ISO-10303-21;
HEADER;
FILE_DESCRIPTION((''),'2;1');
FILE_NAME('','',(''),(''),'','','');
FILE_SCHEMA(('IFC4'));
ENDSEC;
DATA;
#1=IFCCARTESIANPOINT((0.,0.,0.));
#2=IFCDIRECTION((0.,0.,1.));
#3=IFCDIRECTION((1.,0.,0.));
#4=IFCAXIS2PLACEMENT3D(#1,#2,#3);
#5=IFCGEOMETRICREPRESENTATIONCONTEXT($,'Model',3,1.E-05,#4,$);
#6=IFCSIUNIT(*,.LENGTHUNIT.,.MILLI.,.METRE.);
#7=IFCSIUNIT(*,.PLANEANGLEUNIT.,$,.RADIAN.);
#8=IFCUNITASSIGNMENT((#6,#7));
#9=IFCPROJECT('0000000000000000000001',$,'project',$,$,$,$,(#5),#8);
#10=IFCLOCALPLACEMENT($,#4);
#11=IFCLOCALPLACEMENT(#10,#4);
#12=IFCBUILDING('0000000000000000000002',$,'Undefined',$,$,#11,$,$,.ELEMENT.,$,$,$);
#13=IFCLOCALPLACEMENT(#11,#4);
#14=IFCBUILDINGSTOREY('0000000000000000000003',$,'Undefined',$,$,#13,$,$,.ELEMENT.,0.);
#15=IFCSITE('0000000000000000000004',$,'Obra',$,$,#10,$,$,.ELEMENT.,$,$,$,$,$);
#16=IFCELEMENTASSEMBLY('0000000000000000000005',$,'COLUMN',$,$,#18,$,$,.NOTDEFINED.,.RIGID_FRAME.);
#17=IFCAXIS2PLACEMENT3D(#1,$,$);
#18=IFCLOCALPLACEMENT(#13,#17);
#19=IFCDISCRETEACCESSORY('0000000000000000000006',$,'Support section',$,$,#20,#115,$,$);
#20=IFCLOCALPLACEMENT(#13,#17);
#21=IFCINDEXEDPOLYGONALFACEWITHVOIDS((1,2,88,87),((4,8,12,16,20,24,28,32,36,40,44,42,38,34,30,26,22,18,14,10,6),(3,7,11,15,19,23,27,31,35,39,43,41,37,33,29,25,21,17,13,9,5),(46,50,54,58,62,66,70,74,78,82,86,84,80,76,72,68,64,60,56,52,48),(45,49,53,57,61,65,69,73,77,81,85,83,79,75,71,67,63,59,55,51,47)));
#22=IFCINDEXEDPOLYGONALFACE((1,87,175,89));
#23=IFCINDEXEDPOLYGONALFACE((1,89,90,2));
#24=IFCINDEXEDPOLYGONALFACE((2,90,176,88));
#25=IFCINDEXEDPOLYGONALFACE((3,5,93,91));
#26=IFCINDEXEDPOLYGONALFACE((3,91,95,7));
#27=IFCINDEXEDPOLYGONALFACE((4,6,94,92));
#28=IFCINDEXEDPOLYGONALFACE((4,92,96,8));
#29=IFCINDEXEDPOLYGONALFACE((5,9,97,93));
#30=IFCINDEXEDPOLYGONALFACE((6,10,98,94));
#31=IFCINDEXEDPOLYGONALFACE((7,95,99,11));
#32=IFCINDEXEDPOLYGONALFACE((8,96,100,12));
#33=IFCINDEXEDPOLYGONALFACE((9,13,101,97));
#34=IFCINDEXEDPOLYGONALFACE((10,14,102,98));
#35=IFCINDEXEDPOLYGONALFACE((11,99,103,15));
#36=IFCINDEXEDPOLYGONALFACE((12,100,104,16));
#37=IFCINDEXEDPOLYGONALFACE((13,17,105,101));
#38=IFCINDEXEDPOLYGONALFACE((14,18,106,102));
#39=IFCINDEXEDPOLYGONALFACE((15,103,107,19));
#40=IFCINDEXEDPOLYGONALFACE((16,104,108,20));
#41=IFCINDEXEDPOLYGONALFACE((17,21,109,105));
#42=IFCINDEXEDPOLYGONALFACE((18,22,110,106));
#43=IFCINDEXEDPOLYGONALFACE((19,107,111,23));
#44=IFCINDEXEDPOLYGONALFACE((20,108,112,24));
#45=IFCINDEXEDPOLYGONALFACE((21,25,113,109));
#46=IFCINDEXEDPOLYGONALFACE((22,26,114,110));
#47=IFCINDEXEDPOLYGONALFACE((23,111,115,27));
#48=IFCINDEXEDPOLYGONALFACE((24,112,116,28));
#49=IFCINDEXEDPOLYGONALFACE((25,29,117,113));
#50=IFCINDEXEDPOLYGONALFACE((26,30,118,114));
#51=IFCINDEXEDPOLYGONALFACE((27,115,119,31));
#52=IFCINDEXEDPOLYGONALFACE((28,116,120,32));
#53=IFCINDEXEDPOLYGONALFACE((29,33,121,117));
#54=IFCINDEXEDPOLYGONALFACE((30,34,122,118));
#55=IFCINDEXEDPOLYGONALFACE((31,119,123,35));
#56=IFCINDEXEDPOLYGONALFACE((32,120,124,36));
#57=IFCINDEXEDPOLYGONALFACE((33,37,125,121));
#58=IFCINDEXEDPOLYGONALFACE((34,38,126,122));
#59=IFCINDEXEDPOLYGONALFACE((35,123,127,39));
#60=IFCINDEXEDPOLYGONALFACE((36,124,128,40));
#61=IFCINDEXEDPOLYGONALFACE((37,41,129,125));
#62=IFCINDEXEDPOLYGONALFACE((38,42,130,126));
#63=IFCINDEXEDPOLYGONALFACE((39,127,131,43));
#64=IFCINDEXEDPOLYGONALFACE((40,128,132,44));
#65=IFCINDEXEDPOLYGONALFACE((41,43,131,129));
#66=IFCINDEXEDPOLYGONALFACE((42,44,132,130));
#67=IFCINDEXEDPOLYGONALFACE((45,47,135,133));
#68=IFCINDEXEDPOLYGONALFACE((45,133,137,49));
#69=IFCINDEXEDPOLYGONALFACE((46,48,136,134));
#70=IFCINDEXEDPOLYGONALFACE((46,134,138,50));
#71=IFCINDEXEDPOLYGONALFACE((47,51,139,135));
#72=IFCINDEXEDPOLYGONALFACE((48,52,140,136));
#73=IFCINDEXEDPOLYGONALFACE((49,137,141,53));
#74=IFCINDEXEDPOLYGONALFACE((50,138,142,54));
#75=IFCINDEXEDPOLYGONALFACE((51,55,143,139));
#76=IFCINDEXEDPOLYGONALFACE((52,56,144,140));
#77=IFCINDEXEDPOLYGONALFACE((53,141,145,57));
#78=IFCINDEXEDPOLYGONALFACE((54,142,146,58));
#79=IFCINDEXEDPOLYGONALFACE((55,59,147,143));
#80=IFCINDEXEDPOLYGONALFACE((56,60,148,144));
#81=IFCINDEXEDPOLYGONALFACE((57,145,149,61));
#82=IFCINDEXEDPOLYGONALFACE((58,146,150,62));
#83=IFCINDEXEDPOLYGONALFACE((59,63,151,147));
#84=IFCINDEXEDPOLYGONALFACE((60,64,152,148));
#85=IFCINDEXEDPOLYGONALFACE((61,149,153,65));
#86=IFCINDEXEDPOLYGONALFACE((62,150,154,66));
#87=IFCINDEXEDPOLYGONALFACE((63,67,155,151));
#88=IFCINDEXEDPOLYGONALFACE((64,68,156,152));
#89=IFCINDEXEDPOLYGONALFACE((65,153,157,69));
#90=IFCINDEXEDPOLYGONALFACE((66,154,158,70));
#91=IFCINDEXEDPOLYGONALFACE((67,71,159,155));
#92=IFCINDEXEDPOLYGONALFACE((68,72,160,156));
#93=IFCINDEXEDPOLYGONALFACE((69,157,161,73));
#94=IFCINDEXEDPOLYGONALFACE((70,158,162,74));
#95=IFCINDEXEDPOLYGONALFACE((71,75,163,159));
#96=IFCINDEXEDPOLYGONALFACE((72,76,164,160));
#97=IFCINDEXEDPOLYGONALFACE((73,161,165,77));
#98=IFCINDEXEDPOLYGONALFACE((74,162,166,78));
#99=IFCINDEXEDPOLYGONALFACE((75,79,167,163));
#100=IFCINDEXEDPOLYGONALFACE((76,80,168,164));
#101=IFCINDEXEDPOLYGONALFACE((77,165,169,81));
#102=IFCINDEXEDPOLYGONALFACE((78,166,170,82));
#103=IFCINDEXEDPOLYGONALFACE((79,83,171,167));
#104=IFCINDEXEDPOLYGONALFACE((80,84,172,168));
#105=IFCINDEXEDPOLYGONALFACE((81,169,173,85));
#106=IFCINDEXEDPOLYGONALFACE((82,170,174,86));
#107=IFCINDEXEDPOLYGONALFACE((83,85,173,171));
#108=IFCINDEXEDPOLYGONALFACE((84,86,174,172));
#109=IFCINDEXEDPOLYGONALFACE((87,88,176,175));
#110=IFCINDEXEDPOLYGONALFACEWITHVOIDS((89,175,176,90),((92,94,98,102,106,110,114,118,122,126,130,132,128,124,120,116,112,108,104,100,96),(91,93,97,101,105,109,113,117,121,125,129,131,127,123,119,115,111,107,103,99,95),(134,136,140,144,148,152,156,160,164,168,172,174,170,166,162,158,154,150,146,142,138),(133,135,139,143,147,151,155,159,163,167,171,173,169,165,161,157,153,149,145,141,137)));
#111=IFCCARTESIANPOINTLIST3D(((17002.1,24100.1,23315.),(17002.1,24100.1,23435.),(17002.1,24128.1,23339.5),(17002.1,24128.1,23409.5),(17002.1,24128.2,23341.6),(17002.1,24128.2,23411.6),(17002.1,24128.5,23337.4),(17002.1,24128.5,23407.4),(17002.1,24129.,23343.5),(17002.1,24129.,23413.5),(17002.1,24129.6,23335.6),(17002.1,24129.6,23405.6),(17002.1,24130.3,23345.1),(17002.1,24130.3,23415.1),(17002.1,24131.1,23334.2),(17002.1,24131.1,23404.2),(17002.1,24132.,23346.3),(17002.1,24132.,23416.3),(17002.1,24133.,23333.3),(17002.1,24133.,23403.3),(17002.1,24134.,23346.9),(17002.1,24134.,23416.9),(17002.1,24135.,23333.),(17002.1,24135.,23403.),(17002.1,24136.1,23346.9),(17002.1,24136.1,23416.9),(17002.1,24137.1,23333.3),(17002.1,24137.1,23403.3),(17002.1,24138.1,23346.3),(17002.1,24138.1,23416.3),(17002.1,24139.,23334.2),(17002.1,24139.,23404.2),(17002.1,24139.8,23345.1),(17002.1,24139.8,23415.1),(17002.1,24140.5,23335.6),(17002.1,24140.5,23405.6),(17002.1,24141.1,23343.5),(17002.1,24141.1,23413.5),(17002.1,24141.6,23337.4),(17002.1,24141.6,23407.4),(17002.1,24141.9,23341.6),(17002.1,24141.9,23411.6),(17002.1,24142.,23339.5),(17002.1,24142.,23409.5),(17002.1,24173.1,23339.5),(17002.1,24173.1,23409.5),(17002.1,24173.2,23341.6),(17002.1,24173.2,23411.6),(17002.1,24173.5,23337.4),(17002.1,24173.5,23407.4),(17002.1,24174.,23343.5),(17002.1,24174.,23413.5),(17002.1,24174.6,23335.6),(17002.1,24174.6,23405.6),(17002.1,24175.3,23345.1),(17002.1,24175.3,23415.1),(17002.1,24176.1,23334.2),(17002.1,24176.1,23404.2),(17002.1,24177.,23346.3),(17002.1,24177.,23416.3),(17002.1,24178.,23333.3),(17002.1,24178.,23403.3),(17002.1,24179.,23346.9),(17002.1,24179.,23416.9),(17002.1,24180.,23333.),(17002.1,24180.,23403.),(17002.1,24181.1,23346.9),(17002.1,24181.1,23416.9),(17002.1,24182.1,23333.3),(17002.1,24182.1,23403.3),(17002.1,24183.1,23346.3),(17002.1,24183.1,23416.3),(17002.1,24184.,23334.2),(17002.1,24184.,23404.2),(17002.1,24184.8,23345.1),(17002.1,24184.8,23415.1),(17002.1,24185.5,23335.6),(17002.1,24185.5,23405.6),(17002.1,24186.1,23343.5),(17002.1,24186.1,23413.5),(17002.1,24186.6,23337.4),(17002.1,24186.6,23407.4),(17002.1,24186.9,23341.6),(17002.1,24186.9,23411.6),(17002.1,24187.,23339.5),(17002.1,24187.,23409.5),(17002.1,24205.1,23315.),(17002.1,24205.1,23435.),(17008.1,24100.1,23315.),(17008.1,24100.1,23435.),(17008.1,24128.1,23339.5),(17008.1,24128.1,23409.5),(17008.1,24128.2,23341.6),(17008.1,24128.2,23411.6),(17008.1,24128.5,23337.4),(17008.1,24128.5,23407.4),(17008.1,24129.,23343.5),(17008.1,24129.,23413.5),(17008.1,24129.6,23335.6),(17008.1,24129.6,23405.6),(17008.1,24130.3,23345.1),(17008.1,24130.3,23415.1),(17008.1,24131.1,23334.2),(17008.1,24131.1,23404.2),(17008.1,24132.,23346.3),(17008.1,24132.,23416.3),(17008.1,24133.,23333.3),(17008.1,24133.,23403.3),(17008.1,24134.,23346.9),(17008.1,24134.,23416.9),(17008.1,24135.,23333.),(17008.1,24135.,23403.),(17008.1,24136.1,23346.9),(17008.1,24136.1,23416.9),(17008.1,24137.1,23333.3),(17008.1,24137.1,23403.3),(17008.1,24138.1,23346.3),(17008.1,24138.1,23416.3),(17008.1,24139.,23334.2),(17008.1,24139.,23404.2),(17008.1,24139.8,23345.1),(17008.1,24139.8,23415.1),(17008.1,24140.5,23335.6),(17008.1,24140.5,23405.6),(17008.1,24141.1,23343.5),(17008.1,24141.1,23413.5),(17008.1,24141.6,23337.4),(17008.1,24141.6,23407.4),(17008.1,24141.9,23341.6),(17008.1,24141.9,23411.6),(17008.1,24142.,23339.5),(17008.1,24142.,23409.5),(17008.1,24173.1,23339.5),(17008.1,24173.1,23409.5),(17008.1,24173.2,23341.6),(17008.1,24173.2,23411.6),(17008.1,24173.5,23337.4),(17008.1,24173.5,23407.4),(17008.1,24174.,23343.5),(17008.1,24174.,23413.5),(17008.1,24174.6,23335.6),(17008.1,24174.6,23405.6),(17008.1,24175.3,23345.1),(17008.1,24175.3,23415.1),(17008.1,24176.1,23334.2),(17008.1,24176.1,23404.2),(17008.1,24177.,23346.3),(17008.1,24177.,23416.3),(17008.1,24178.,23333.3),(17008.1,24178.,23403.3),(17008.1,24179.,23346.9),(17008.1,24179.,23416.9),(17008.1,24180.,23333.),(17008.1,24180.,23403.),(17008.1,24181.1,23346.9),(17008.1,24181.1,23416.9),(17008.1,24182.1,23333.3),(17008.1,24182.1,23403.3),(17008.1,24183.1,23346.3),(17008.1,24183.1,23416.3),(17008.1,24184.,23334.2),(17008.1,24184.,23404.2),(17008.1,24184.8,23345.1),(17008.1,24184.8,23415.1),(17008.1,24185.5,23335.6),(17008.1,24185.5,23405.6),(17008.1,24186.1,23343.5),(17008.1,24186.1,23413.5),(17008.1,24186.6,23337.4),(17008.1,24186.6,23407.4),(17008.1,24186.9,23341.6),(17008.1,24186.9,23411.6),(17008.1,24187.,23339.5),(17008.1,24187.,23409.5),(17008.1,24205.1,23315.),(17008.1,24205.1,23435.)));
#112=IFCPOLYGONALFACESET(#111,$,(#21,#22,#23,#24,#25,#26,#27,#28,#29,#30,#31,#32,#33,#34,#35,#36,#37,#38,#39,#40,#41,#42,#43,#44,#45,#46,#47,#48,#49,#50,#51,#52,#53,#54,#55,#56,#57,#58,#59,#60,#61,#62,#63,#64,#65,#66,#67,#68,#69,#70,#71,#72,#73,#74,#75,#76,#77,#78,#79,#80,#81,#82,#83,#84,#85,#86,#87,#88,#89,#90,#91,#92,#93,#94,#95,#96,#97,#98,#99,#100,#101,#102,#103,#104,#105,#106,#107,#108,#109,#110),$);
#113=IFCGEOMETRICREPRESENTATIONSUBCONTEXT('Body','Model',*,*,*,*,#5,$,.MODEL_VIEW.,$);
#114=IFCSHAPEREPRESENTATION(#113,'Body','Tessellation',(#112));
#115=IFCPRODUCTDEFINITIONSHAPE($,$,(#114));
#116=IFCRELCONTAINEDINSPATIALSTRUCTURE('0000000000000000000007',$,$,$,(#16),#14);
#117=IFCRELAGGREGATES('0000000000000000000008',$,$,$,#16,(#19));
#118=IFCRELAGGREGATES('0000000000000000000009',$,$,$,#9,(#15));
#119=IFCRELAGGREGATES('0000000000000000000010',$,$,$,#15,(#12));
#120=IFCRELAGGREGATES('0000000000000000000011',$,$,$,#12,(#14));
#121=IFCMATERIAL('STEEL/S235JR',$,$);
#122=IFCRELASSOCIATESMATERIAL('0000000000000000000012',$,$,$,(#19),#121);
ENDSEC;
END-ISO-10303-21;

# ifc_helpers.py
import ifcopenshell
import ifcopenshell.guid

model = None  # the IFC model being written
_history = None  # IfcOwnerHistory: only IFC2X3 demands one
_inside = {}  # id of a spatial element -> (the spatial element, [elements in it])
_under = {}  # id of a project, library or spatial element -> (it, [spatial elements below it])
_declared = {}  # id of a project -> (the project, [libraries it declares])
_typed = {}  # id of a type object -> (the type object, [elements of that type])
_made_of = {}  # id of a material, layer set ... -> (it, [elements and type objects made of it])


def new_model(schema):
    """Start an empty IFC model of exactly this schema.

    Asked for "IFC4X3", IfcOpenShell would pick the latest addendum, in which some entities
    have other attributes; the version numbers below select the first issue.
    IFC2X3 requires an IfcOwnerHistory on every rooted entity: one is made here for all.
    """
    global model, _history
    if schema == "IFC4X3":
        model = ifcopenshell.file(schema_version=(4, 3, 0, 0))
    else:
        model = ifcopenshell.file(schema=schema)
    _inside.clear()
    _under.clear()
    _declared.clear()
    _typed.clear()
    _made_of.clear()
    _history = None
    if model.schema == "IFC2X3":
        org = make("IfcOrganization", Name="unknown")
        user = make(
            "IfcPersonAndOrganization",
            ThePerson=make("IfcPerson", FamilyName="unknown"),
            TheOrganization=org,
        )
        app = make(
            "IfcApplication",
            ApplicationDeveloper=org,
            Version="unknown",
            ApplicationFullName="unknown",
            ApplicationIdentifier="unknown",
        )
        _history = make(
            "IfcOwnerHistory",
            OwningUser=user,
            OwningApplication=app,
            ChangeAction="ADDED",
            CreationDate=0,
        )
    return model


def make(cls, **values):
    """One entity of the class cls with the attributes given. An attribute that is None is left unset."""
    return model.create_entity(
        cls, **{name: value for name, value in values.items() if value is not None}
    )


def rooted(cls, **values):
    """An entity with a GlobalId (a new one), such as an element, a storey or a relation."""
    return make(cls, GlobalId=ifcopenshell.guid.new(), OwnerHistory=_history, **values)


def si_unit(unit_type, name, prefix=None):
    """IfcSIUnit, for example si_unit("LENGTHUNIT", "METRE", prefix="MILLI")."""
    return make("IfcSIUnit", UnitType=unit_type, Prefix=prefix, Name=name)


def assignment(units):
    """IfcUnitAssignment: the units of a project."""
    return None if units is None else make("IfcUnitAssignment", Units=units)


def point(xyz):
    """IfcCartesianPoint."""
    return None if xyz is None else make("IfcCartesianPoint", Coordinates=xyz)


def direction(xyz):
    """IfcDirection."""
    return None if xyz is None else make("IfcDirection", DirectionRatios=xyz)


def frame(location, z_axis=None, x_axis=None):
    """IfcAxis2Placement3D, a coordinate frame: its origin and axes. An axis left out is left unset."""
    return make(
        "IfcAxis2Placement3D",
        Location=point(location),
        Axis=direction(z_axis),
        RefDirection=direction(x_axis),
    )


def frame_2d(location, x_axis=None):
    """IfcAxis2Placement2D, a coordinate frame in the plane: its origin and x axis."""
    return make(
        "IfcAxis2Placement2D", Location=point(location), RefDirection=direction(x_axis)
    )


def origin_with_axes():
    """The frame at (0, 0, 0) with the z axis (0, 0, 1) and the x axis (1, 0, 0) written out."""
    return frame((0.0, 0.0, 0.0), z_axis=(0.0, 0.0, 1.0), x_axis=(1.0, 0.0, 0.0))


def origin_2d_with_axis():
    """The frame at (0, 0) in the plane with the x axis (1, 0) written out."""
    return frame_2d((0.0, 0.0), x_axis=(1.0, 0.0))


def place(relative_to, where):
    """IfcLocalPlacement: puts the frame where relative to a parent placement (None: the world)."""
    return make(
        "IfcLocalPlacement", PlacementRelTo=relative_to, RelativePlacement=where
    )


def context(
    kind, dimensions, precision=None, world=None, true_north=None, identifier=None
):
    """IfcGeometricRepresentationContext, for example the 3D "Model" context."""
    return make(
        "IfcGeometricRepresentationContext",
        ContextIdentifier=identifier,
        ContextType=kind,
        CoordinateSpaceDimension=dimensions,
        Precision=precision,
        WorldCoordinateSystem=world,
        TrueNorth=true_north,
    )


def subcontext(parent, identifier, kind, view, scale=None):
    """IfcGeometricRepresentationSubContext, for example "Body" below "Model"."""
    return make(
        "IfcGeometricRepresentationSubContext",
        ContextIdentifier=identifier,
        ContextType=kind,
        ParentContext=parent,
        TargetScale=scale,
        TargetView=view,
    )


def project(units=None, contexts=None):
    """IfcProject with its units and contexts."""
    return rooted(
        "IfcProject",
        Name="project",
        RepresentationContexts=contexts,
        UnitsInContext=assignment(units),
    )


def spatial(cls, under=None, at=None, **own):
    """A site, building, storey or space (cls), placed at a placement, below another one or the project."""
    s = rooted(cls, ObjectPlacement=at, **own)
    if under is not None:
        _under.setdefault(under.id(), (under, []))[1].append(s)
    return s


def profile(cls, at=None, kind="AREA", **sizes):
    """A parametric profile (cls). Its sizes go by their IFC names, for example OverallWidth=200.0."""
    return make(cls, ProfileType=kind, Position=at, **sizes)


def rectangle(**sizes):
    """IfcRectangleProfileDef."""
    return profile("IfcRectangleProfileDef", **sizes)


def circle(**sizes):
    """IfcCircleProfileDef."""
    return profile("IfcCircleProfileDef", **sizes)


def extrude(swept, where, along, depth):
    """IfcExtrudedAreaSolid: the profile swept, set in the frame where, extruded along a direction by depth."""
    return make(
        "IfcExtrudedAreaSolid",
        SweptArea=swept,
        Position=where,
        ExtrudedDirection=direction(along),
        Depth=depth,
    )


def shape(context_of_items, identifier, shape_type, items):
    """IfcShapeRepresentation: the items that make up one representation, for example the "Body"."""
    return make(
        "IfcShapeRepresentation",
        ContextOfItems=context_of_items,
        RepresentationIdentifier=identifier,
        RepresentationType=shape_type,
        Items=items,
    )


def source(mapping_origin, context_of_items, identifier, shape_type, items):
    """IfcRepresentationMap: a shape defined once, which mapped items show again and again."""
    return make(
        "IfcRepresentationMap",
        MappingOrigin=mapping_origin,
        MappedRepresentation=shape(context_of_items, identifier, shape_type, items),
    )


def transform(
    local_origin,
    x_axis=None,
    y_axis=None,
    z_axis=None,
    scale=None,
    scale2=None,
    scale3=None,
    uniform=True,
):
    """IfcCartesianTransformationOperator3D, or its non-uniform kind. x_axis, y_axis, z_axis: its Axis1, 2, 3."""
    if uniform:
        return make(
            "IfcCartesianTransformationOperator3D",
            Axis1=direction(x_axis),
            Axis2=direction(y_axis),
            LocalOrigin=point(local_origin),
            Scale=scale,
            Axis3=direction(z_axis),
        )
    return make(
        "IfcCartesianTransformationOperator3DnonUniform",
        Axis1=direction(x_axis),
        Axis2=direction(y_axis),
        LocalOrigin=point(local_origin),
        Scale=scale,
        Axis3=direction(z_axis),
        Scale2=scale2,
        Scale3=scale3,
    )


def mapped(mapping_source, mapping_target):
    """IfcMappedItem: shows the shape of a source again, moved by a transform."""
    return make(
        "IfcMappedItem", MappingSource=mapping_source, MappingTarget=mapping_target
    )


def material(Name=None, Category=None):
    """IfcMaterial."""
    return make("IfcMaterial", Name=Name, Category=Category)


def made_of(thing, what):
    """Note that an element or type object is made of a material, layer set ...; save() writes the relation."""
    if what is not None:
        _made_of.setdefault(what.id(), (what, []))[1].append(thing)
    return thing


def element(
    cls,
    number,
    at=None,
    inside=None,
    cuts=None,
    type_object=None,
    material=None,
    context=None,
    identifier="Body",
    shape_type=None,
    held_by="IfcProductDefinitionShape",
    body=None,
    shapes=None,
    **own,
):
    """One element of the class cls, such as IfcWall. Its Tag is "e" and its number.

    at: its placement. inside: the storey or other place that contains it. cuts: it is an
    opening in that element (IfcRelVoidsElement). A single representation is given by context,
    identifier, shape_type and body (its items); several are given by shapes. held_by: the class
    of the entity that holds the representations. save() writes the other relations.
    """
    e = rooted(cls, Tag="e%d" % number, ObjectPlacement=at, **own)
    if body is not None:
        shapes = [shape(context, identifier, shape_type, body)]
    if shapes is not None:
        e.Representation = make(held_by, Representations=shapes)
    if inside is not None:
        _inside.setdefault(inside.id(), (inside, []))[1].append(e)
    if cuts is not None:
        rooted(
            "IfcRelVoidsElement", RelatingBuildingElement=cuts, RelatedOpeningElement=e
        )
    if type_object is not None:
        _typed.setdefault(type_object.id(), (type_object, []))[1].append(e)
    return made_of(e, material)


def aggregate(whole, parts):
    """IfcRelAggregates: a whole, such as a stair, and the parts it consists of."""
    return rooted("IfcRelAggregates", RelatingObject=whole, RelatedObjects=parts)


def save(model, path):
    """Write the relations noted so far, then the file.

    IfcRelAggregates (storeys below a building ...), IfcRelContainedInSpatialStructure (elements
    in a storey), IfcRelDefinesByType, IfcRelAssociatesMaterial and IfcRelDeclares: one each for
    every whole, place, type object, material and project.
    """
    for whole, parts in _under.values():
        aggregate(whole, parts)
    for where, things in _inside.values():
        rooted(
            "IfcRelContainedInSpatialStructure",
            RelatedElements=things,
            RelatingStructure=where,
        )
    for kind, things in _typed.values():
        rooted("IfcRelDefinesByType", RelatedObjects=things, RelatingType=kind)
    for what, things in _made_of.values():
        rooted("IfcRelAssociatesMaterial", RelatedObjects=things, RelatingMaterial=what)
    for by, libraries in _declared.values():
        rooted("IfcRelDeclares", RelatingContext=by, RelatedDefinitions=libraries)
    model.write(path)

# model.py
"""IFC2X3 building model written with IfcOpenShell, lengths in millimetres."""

from ifc_helpers import new_model, si_unit, frame, origin_with_axes, origin_2d_with_axis, place, context, subcontext, project, spatial, rectangle, circle, extrude, source, transform, mapped, material, element, aggregate, save


model = new_model("IFC2X3")

# Units and contexts
model_context = context("Model", 3, precision=1e-05, world=origin_with_axes())
body_context = subcontext(model_context, "Body", "Model", "MODEL_VIEW")
ifc_project = project(units=[si_unit("LENGTHUNIT", "METRE", prefix="MILLI"), si_unit("PLANEANGLEUNIT", "RADIAN")], contexts=[model_context])

# Site, building, storey
site_placement = place(None, origin_with_axes())
site = spatial("IfcSite", under=ifc_project, at=site_placement, Name="Obra", CompositionType="ELEMENT")
building_placement = place(site_placement, origin_with_axes())
building = spatial("IfcBuilding", under=site, at=building_placement, Name="Undefined", CompositionType="ELEMENT")
storey_placement = place(building_placement, origin_with_axes())
storey = spatial("IfcBuildingStorey", under=building, at=storey_placement, Name="Undefined", CompositionType="ELEMENT", Elevation=0.0)

# Element assembly
ifc_material_1 = material(Name="STEEL/S235JR")
assembly_1_placement = place(storey_placement, origin_with_axes())
assembly_1 = element("IfcElementAssembly", 1, at=assembly_1_placement, inside=storey, Name="COLUMN", AssemblyPlace="NOTDEFINED", PredefinedType="RIGID_FRAME")

# Discrete accessory, opening
discrete_accessory_1_placement = place(assembly_1_placement, frame((17005.1, 24152.6, 23315.0), z_axis=(0.0, 0.0, 1.0), x_axis=(0.0, -1.0, 0.0)))
discrete_accessory_1 = element("IfcDiscreteAccessory", 2, at=discrete_accessory_1_placement, material=ifc_material_1, Name="Support section", context=body_context, shape_type="SweptSolid", body=[
    extrude(rectangle(XDim=6.0, YDim=105.0, at=origin_2d_with_axis()), frame((0.0, 0.0, 120.0), z_axis=(0.0, 0.0, -1.0), x_axis=(0.0, 1.0, 0.0)), (0.0, 0.0, 1.0), 120.0),
])
shared_shape_1 = source(origin_with_axes(), body_context, "Body", "SweptSolid", [
    extrude(circle(Radius=7.0, at=origin_2d_with_axis()), frame((0.0, -8.6, 0.0), z_axis=(0.0, 1.0, 0.0), x_axis=(1.0, 0.0, 0.0)), (0.0, 0.0, 1.0), 6.2),
])
opening_1_placement = place(assembly_1_placement, frame((16999.6, 24110.0, 23455.0), z_axis=(0.0, 1.0, 0.0), x_axis=(0.0, 0.0, -1.0)))
element("IfcOpeningElement", 3, at=opening_1_placement, cuts=discrete_accessory_1, ObjectType="Opening", context=body_context, shape_type="MappedRepresentation", body=[
    mapped(shared_shape_1, transform((45.0, 0.0, 25.0))),
    mapped(shared_shape_1, transform((45.0, 0.0, 70.0))),
    mapped(shared_shape_1, transform((115.0, 0.0, 25.0))),
    mapped(shared_shape_1, transform((115.0, 0.0, 70.0))),
])
aggregate(assembly_1, [discrete_accessory_1])

save(model, "model.ifc")
